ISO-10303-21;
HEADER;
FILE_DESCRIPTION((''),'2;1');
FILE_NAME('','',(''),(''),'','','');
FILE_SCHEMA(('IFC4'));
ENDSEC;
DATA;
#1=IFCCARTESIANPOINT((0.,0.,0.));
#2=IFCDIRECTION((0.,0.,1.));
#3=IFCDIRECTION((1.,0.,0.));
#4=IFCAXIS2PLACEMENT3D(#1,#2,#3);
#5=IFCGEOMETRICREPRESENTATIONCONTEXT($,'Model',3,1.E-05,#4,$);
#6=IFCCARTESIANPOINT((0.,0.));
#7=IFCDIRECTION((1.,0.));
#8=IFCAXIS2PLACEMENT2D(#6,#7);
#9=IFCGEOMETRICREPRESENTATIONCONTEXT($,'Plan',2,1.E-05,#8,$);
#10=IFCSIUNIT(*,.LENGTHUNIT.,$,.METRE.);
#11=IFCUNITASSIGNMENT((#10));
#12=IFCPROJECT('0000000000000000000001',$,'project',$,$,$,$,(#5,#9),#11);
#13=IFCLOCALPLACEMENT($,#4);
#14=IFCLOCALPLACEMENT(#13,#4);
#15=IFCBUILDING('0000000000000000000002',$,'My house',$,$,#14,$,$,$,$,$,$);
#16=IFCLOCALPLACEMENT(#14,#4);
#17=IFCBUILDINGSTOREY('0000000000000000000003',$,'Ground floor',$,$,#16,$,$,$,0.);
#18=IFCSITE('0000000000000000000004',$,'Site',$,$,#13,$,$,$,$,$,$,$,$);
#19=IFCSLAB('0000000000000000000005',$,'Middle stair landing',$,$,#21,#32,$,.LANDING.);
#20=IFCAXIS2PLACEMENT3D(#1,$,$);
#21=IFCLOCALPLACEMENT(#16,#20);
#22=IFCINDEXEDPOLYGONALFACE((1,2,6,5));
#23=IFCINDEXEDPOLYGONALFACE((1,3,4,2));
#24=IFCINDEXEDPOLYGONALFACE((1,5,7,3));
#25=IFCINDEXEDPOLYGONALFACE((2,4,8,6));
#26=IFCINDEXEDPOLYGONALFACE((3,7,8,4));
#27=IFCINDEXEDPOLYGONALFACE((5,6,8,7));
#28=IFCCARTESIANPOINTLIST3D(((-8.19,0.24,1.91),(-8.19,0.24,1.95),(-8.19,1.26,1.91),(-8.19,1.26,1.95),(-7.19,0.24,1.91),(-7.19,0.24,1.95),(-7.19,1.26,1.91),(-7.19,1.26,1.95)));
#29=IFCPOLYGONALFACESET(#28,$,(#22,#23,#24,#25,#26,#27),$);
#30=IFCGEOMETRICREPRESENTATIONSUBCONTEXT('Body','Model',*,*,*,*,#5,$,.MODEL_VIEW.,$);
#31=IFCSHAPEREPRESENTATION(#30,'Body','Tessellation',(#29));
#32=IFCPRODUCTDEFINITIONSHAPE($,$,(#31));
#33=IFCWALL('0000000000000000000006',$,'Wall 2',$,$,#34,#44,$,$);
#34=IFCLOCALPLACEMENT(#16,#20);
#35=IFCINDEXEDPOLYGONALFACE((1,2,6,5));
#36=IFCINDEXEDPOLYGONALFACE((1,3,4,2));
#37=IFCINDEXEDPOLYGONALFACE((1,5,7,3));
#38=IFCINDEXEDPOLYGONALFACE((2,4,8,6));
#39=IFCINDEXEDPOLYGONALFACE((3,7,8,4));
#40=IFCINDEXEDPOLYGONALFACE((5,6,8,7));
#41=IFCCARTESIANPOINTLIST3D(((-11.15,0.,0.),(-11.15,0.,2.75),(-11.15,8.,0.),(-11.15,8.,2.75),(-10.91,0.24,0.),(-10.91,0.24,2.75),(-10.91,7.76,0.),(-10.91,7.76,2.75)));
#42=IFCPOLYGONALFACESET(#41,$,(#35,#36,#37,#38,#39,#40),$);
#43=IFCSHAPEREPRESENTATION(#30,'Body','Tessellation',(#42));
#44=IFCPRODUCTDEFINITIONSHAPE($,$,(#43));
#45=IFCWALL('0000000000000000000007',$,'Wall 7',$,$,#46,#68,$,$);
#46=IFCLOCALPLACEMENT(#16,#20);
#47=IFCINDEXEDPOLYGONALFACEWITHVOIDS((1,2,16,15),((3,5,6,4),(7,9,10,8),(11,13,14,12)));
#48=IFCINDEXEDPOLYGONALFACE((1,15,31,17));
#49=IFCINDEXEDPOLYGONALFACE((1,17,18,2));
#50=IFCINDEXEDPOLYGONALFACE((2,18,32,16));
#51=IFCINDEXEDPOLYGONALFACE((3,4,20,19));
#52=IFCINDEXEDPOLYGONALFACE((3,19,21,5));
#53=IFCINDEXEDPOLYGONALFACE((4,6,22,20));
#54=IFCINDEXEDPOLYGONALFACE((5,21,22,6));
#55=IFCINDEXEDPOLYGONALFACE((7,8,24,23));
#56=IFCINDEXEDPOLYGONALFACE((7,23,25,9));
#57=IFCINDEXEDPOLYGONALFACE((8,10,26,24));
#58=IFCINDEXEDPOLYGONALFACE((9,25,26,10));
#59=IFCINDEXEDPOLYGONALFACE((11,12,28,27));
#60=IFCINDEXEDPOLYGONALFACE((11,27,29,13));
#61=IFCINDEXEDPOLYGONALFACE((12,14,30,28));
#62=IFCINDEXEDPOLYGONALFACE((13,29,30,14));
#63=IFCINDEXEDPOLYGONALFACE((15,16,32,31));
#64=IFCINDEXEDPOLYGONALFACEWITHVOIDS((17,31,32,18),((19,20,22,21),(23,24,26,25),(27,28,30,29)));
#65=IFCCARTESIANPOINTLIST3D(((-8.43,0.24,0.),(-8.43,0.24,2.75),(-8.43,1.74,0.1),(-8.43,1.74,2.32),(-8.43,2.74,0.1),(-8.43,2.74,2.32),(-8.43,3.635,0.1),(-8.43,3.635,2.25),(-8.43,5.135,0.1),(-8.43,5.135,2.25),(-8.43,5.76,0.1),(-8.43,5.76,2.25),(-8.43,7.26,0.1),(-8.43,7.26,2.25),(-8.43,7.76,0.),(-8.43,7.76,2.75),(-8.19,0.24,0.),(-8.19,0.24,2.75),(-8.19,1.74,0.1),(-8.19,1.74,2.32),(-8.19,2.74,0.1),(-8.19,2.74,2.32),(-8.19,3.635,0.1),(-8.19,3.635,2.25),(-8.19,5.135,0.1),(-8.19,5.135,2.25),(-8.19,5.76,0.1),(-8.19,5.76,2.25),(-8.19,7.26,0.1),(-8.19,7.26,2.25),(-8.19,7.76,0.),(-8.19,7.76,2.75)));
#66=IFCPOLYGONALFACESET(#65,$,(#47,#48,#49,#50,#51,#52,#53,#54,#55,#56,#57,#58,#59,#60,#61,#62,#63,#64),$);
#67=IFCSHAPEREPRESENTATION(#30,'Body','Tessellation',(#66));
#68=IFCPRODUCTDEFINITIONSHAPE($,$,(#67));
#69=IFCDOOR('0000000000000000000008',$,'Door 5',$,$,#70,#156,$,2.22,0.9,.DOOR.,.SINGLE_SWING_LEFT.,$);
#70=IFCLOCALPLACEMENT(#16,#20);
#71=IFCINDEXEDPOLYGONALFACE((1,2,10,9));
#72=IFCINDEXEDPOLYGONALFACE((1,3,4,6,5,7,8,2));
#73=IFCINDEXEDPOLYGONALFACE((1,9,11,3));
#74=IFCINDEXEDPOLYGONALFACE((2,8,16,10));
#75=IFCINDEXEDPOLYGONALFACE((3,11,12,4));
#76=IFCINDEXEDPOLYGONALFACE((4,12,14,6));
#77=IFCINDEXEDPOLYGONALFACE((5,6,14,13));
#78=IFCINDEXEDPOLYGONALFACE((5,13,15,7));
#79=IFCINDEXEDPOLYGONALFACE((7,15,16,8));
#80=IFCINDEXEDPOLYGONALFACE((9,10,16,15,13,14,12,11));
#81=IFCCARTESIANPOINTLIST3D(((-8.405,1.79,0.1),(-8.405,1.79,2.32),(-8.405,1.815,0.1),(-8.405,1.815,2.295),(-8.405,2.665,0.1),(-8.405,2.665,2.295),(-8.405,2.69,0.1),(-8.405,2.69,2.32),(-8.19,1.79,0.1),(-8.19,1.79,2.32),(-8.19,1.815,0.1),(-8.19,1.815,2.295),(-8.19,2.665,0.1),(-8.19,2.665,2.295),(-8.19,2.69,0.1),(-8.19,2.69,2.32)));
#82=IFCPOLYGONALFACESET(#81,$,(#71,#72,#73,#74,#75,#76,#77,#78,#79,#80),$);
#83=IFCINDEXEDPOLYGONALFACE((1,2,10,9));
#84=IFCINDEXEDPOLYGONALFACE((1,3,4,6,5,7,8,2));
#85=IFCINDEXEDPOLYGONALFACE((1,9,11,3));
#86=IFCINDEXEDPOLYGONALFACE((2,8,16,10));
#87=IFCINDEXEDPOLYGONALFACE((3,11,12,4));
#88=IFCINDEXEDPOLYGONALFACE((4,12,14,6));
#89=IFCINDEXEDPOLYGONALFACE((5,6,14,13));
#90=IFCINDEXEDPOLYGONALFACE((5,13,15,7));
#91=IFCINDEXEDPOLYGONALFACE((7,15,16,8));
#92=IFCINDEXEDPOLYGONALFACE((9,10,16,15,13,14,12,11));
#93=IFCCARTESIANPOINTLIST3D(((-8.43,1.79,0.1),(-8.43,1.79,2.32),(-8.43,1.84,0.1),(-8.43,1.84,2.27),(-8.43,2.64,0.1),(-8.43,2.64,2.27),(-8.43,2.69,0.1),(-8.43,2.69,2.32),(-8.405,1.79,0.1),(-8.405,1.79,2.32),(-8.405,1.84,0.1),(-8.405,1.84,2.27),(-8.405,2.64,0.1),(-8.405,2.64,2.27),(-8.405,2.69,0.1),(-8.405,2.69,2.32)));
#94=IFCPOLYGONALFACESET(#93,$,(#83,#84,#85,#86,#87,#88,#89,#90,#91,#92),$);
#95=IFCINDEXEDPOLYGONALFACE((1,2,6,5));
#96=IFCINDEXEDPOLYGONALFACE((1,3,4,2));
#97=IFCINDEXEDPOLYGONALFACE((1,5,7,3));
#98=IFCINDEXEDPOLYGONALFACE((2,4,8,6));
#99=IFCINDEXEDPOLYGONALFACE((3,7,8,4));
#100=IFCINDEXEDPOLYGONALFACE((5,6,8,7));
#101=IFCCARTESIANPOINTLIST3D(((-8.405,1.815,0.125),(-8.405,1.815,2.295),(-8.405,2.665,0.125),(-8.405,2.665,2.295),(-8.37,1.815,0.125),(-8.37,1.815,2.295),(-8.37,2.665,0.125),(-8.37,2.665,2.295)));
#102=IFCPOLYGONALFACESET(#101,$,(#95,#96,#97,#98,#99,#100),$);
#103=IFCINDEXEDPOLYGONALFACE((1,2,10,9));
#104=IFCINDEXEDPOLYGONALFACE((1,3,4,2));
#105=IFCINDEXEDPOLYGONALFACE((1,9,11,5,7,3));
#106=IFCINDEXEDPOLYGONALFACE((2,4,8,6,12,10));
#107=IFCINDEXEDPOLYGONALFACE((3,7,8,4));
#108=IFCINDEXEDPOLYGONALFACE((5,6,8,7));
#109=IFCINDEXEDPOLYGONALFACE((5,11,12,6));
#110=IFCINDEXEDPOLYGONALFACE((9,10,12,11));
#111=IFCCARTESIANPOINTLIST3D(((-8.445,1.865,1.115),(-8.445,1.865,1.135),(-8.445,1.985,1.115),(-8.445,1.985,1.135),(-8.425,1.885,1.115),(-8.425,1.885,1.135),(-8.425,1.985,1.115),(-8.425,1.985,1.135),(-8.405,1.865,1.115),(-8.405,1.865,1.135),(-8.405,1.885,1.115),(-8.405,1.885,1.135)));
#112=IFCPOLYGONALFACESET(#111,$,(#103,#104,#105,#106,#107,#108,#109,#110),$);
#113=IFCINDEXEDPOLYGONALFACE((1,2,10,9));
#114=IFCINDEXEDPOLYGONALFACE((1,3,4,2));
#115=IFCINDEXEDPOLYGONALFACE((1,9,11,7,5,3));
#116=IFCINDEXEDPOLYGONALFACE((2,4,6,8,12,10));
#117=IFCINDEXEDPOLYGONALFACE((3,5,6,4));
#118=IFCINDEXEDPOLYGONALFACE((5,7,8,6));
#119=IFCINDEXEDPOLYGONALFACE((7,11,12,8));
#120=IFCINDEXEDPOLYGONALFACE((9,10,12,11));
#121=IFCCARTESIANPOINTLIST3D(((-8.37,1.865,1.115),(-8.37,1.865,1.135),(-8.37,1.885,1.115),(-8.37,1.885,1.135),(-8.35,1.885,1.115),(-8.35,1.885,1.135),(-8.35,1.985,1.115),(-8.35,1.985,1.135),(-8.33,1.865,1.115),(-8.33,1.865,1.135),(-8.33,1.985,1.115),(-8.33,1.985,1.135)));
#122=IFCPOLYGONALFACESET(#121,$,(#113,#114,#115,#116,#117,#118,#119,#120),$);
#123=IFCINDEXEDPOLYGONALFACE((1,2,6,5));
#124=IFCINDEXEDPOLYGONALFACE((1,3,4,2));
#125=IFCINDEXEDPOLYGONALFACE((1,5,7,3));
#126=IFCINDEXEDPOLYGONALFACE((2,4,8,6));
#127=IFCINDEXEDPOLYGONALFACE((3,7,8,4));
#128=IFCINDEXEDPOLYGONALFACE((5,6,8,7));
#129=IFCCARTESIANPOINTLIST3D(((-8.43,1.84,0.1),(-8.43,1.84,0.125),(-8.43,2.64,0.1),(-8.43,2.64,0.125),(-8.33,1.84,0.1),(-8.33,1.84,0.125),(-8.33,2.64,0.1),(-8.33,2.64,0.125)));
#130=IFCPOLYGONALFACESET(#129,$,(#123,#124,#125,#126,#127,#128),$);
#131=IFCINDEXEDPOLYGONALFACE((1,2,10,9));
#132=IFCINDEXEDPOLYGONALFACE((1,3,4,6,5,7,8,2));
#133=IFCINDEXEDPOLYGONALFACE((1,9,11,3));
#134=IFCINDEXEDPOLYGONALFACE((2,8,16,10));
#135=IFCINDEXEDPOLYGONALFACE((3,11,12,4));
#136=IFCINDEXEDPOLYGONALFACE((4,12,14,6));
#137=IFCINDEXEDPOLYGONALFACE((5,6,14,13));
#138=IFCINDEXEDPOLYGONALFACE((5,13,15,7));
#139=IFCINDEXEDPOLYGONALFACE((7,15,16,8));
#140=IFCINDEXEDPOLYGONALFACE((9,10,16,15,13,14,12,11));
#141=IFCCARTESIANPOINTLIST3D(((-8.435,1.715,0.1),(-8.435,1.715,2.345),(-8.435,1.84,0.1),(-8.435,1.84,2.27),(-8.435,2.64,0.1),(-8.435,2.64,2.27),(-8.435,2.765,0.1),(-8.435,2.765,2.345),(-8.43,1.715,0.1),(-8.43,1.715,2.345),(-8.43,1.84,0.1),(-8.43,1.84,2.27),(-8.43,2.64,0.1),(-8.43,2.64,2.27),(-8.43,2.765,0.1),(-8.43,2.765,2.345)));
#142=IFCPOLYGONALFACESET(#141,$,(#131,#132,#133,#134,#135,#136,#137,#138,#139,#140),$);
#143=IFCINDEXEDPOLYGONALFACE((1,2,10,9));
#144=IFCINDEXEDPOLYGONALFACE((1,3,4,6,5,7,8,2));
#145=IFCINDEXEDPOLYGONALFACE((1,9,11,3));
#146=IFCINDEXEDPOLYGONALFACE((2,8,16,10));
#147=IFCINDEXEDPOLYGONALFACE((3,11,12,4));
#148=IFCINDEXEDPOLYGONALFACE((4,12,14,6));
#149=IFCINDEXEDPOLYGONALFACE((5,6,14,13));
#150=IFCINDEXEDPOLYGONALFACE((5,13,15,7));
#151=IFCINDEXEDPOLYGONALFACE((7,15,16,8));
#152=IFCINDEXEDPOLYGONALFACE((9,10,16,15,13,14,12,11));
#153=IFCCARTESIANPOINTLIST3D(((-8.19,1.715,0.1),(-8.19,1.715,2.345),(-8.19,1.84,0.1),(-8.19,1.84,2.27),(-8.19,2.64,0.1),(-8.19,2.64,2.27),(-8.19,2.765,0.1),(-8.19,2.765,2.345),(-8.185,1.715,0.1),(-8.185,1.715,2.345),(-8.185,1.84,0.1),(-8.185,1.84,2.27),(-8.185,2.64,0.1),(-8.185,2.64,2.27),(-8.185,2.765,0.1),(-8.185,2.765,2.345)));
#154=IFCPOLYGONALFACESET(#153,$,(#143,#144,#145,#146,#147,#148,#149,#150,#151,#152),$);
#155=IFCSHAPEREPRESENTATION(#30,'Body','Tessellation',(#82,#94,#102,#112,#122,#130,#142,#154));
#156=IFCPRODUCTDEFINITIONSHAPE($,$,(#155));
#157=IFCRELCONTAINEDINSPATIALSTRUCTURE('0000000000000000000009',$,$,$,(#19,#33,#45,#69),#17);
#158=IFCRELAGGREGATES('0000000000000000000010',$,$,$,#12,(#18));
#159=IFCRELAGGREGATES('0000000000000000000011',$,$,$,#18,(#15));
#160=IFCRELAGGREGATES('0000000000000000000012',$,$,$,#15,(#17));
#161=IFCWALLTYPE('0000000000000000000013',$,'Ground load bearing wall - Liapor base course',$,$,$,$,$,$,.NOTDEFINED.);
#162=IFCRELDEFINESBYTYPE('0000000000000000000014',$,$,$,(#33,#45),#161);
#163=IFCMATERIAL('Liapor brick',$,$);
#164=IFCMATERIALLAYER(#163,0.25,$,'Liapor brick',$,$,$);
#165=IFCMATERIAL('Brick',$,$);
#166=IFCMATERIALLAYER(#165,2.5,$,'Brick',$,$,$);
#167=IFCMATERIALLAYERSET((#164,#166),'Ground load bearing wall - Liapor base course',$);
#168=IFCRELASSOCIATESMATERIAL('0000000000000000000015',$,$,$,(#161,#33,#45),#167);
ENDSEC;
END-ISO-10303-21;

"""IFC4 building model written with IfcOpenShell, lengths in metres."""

from ifc_helpers import new_model, entity, si_unit, frame, origin_with_axes, origin_2d_with_axis, place, context, subcontext, project, spatial, line, indexed_curve, outline, extrude, shape, source, transform, mapped, material, layer, layer_set, layer_usage, type_object, element, fill, save


model = new_model("IFC4")

# Units and contexts
model_context = context("Model", 3, precision=1e-05, world=origin_with_axes())
plan_context = context("Plan", 2, precision=1e-05, world=origin_2d_with_axis())
body_context_1 = subcontext(model_context, "Body", "Model", "MODEL_VIEW")
body_context_2 = subcontext(plan_context, "Body", "Plan", "PLAN_VIEW")
ifc_project = project(units=[si_unit("LENGTHUNIT", "METRE")], contexts=[model_context, plan_context])

# Site, building, storey
site_placement = place(None, origin_with_axes())
site = spatial("IfcSite", under=ifc_project, at=site_placement, Name="Site")
building_placement = place(site_placement, origin_with_axes())
building = spatial("IfcBuilding", under=site, at=building_placement, Name="My house")
storey_placement = place(building_placement, origin_with_axes())
storey = spatial("IfcBuildingStorey", under=building, at=storey_placement, Name="Ground floor", Elevation=0.0)

# Slab
shared_shape_1 = source(origin_with_axes(), body_context_1, "Body", "SweptSolid", [
    extrude(outline(indexed_curve([(0.0, 0.0), (1.0, 0.0), (1.0, 1.02), (0.0, 1.02)])), None, (0.0, 0.0, 1.0), 0.04),
])
slab_placement = place(storey_placement, frame((-7.19, 0.24, 1.91), z_axis=(0.0, 0.0, 1.0), x_axis=(1.0, 0.0, 0.0)))
element("IfcSlab", 1, at=slab_placement, inside=storey, Name="Middle stair landing", PredefinedType="LANDING", context=body_context_1, shape_type="MappedRepresentation", body=[
    mapped(shared_shape_1, transform((0.0, 0.0, 0.0), x_axis=(-1.0, 0.0, 0.0), y_axis=(0.0, 1.0, 0.0), z_axis=(0.0, 0.0, 1.0), scale=1.0)),
])

# Wall
ifc_material_1 = material(Name="Liapor brick")
ifc_layer_1 = layer(ifc_material_1, 0.25, Name="Liapor brick")
ifc_material_2 = material(Name="Brick")
ifc_layer_2 = layer(ifc_material_2, 2.5, Name="Brick")
ifc_layer_set_1 = layer_set([ifc_layer_1, ifc_layer_2], Name="Ground load bearing wall - Liapor base course")
ifc_layer_usage_1 = layer_usage(ifc_layer_set_1, "AXIS3", "POSITIVE", 0.0)
wall_type_1 = type_object("IfcWallType", Name="Ground load bearing wall - Liapor base course", PredefinedType="NOTDEFINED", material=ifc_layer_set_1)
shared_shape_2 = source(origin_with_axes(), body_context_1, "Body", "SweptSolid", [
    extrude(outline(indexed_curve([(0.0, 0.0), (0.24, 0.24), (7.76, 0.24), (8.0, 0.0)], segments=[line(1, 2, 3, 4, 1)])), origin_with_axes(), (0.0, 0.0, 1.0), 2.75),
])
wall_1_placement = place(storey_placement, frame((-11.15, 0.0, 0.0), z_axis=(0.0, 0.0, 1.0), x_axis=(0.0, -1.0, 0.0)))
element("IfcWall", 2, at=wall_1_placement, inside=storey, type_object=wall_type_1, material=ifc_layer_usage_1, Name="Wall 2", context=body_context_1, shape_type="MappedRepresentation", body=[
    mapped(shared_shape_2, transform((0.0, 0.0, 0.0), x_axis=(-1.0, 0.0, 0.0), y_axis=(0.0, 1.0, 0.0), z_axis=(0.0, 0.0, 1.0), scale=1.0)),
])

# Wall, openings, door
ifc_layer_usage_2 = layer_usage(ifc_layer_set_1, "AXIS3", "POSITIVE", 0.0)
shared_shape_3 = source(origin_with_axes(), body_context_1, "Body", "SweptSolid", [
    extrude(outline(indexed_curve([(0.24, 0.0), (0.24, 0.24), (7.76, 0.24), (7.76, 0.0)], segments=[line(1, 2, 3, 4, 1)])), origin_with_axes(), (0.0, 0.0, 1.0), 2.75),
])
wall_2_placement = place(storey_placement, frame((-8.43, 0.0, 0.0), z_axis=(0.0, 0.0, 1.0), x_axis=(0.0, -1.0, 0.0)))
wall_2 = element("IfcWall", 3, at=wall_2_placement, inside=storey, type_object=wall_type_1, material=ifc_layer_usage_2, Name="Wall 7", context=body_context_1, shape_type="MappedRepresentation", body=[
    mapped(shared_shape_3, transform((0.0, 0.0, 0.0), x_axis=(-1.0, 0.0, 0.0), y_axis=(0.0, 1.0, 0.0), z_axis=(0.0, 0.0, 1.0), scale=1.0)),
])
shared_shape_4 = source(origin_with_axes(), body_context_1, "Body", "SweptSolid", [
    extrude(outline(indexed_curve([(0.0, 0.0), (0.0, 0.34), (1.5, 0.34), (1.5, 0.0), (0.0, 0.0)], self_intersect=False)), frame((0.0, -0.05, 0.0), z_axis=(0.0, 0.0, 1.0), x_axis=(1.0, 0.0, 0.0)), (0.0, 0.0, 1.0), 2.15),
])
opening_1_placement = place(wall_2_placement, frame((-5.76, 0.0, 0.1), z_axis=(0.0, 0.0, 1.0), x_axis=(1.0, 0.0, 0.0)))
element("IfcOpeningElement", 4, at=opening_1_placement, cuts=wall_2, PredefinedType="OPENING", context=body_context_1, shape_type="MappedRepresentation", body=[
    mapped(shared_shape_4, transform((0.0, 0.0, 0.0), x_axis=(-1.0, 0.0, 0.0), y_axis=(0.0, 1.0, 0.0), z_axis=(0.0, 0.0, 1.0), scale=1.0)),
])
shared_shape_5 = source(origin_with_axes(), body_context_1, "Body", "SweptSolid", [
    extrude(outline(indexed_curve([(0.0, 0.0), (0.0, 0.34), (1.5, 0.34), (1.5, 0.0), (0.0, 0.0)], self_intersect=False)), frame((0.0, -0.05, 0.0), z_axis=(0.0, 0.0, 1.0), x_axis=(1.0, 0.0, 0.0)), (0.0, 0.0, 1.0), 2.15),
])
opening_2_placement = place(wall_2_placement, frame((-3.635, 0.0, 0.1), z_axis=(0.0, 0.0, 1.0), x_axis=(1.0, 0.0, 0.0)))
element("IfcOpeningElement", 5, at=opening_2_placement, cuts=wall_2, PredefinedType="OPENING", context=body_context_1, shape_type="MappedRepresentation", body=[
    mapped(shared_shape_5, transform((0.0, 0.0, 0.0), x_axis=(-1.0, 0.0, 0.0), y_axis=(0.0, 1.0, 0.0), z_axis=(0.0, 0.0, 1.0), scale=1.0)),
])
shared_shape_6 = source(origin_with_axes(), body_context_1, "Body", "SweptSolid", [
    extrude(outline(indexed_curve([(0.0, 0.0), (0.0, 0.34), (1.0, 0.34), (1.0, 0.0), (0.0, 0.0)], self_intersect=False)), frame((0.0, -0.05, 0.0), z_axis=(0.0, 0.0, 1.0), x_axis=(1.0, 0.0, 0.0)), (0.0, 0.0, 1.0), 2.22),
])
opening_3_placement = place(wall_2_placement, frame((-1.74, 0.0, 0.1), z_axis=(0.0, 0.0, 1.0), x_axis=(1.0, 0.0, 0.0)))
opening_3 = element("IfcOpeningElement", 6, at=opening_3_placement, cuts=wall_2, PredefinedType="OPENING", context=body_context_1, shape_type="MappedRepresentation", body=[
    mapped(shared_shape_6, transform((0.0, 0.0, 0.0), x_axis=(-1.0, 0.0, 0.0), y_axis=(0.0, 1.0, 0.0), z_axis=(0.0, 0.0, 1.0), scale=1.0)),
])
shared_indexed_poly_curve_1 = entity("IfcIndexedPolyCurve", entity("IfcCartesianPointList2D", [[-0.075, 0.0], [-0.075, 2.245], [0.975, 2.245], [0.975, 0.0], [0.85, 0.0], [0.85, 2.17], [0.05, 2.17], [0.05, 0.0]]), [entity("IfcLineIndex", [1, 2, 3, 4, 5, 6, 7, 8, 1])])
shared_shape_7 = source(origin_with_axes(), body_context_1, "Body", "SweptSolid", [
    extrude(outline(indexed_curve([(0.0, 0.0), (0.0, 2.22), (0.9, 2.22), (0.9, 0.0), (0.875, 0.0), (0.875, 2.195), (0.025, 2.195), (0.025, 0.0)], segments=[line(1, 2, 3, 4, 5, 6, 7, 8, 1)])), frame((0.0, 0.025, 0.0), z_axis=(0.0, -1.0, 0.0), x_axis=(1.0, 0.0, 0.0)), (0.0, 0.0, -1.0), 0.215),
    extrude(outline(indexed_curve([(0.0, 0.0), (0.0, 2.22), (0.9, 2.22), (0.9, 0.0), (0.85, 0.0), (0.85, 2.17), (0.05, 2.17), (0.05, 0.0)], segments=[line(1, 2, 3, 4, 5, 6, 7, 8, 1)])), frame((0.0, 0.0, 0.0), z_axis=(0.0, -1.0, 0.0), x_axis=(1.0, 0.0, 0.0)), (0.0, 0.0, -1.0), 0.025),
    extrude(outline(indexed_curve([(0.0, 0.0), (0.85, 0.0), (0.85, 0.035), (0.0, 0.035)], segments=[line(1, 2, 3, 4, 1)])), frame((0.025, 0.025, 0.025), z_axis=(0.0, 0.0, 1.0), x_axis=(1.0, 0.0, 0.0)), (0.0, 0.0, 1.0), 2.17),
    extrude(outline(indexed_curve([(0.0, 0.0), (0.0, -0.04), (0.12, -0.04), (0.12, -0.02), (0.02, -0.02), (0.02, 0.0)], segments=[line(1, 2, 3, 4, 5, 6, 1)])), frame((0.075, 0.025, 1.015), z_axis=(0.0, 0.0, 1.0), x_axis=(1.0, 0.0, 0.0)), (0.0, 0.0, 1.0), 0.02),
    extrude(outline(indexed_curve([(0.0, 0.0), (0.0, 0.04), (0.12, 0.04), (0.12, 0.02), (0.02, 0.02), (0.02, 0.0)], segments=[line(1, 2, 3, 4, 5, 6, 1)])), frame((0.075, 0.06, 1.015), z_axis=(0.0, 0.0, 1.0), x_axis=(1.0, 0.0, 0.0)), (0.0, 0.0, 1.0), 0.02),
    extrude(outline(indexed_curve([(0.0, 0.0), (0.8, 0.0), (0.8, 0.1), (0.0, 0.1)], segments=[line(1, 2, 3, 4, 1)])), frame((0.05, 0.0, 0.0), z_axis=(0.0, 0.0, 1.0), x_axis=(1.0, 0.0, 0.0)), (0.0, 0.0, 1.0), 0.025),
    entity("IfcExtrudedAreaSolid", entity("IfcArbitraryClosedProfileDef", "AREA", None, shared_indexed_poly_curve_1), entity("IfcAxis2Placement3D", entity("IfcCartesianPoint", [0.0, -0.005, 0.0]), entity("IfcDirection", [0.0, -1.0, 0.0]), entity("IfcDirection", [1.0, 0.0, 0.0])), entity("IfcDirection", [0.0, 0.0, -1.0]), 0.005),
    entity("IfcExtrudedAreaSolid", entity("IfcArbitraryClosedProfileDef", "AREA", None, shared_indexed_poly_curve_1), entity("IfcAxis2Placement3D", entity("IfcCartesianPoint", [0.0, 0.24, 0.0]), entity("IfcDirection", [0.0, -1.0, 0.0]), entity("IfcDirection", [1.0, 0.0, 0.0])), entity("IfcDirection", [0.0, 0.0, -1.0]), 0.005),
])
shared_shape_8 = source(origin_with_axes(), body_context_2, "Body", "Curve2D", [
    entity("IfcIndexedPolyCurve", entity("IfcCartesianPointList2D", [[0.0, 0.0], [0.0, 0.24], [0.025, 0.24], [0.025, 0.025], [0.05, 0.025], [0.05, 0.0]]), [entity("IfcLineIndex", [1, 2, 3, 4, 5, 6, 1])]),
    entity("IfcIndexedPolyCurve", entity("IfcCartesianPointList2D", [[0.9, 0.0], [0.9, 0.24], [0.875, 0.24], [0.875, 0.025], [0.85, 0.025], [0.85, 0.0]]), [entity("IfcLineIndex", [1, 2, 3, 4, 5, 6, 1])]),
    entity("IfcTrimmedCurve", entity("IfcEllipse", entity("IfcAxis2Placement2D", entity("IfcCartesianPoint", [0.84, 0.0]), entity("IfcDirection", [1.0, 0.0])), 0.815, 0.85), [entity("IfcCartesianPoint", [0.025, 0.0])], [entity("IfcCartesianPoint", [0.84, -0.85])], True, "CARTESIAN"),
    entity("IfcIndexedPolyCurve", entity("IfcCartesianPointList2D", [[0.875, 0.0], [0.84, 0.0], [0.84, -0.85], [0.875, -0.85]]), [entity("IfcLineIndex", [1, 2, 3, 4, 1])]),
])
door_1_placement = place(opening_3_placement, frame((-0.05, 0.0, 0.0), z_axis=(0.0, 0.0, 1.0), x_axis=(1.0, 0.0, 0.0)))
door_1 = element("IfcDoor", 7, at=door_1_placement, inside=storey, Name="Door 5", OperationType="SINGLE_SWING_LEFT", OverallHeight=2.22, OverallWidth=0.9, PredefinedType="DOOR", shapes=[
    shape(body_context_1, "Body", "MappedRepresentation", [mapped(shared_shape_7, transform((0.0, 0.0, 0.0), x_axis=(-1.0, 0.0, 0.0), y_axis=(0.0, 1.0, 0.0), z_axis=(0.0, 0.0, 1.0), scale=1.0))]),
    shape(body_context_2, "Body", "MappedRepresentation", [mapped(shared_shape_8, transform((0.0, 0.0, 0.0), x_axis=(-1.0, 0.0, 0.0), y_axis=(0.0, 1.0, 0.0), z_axis=(0.0, 0.0, 1.0), scale=1.0))]),
])
fill(opening_3, door_1)

save(model, "model.ifc")
